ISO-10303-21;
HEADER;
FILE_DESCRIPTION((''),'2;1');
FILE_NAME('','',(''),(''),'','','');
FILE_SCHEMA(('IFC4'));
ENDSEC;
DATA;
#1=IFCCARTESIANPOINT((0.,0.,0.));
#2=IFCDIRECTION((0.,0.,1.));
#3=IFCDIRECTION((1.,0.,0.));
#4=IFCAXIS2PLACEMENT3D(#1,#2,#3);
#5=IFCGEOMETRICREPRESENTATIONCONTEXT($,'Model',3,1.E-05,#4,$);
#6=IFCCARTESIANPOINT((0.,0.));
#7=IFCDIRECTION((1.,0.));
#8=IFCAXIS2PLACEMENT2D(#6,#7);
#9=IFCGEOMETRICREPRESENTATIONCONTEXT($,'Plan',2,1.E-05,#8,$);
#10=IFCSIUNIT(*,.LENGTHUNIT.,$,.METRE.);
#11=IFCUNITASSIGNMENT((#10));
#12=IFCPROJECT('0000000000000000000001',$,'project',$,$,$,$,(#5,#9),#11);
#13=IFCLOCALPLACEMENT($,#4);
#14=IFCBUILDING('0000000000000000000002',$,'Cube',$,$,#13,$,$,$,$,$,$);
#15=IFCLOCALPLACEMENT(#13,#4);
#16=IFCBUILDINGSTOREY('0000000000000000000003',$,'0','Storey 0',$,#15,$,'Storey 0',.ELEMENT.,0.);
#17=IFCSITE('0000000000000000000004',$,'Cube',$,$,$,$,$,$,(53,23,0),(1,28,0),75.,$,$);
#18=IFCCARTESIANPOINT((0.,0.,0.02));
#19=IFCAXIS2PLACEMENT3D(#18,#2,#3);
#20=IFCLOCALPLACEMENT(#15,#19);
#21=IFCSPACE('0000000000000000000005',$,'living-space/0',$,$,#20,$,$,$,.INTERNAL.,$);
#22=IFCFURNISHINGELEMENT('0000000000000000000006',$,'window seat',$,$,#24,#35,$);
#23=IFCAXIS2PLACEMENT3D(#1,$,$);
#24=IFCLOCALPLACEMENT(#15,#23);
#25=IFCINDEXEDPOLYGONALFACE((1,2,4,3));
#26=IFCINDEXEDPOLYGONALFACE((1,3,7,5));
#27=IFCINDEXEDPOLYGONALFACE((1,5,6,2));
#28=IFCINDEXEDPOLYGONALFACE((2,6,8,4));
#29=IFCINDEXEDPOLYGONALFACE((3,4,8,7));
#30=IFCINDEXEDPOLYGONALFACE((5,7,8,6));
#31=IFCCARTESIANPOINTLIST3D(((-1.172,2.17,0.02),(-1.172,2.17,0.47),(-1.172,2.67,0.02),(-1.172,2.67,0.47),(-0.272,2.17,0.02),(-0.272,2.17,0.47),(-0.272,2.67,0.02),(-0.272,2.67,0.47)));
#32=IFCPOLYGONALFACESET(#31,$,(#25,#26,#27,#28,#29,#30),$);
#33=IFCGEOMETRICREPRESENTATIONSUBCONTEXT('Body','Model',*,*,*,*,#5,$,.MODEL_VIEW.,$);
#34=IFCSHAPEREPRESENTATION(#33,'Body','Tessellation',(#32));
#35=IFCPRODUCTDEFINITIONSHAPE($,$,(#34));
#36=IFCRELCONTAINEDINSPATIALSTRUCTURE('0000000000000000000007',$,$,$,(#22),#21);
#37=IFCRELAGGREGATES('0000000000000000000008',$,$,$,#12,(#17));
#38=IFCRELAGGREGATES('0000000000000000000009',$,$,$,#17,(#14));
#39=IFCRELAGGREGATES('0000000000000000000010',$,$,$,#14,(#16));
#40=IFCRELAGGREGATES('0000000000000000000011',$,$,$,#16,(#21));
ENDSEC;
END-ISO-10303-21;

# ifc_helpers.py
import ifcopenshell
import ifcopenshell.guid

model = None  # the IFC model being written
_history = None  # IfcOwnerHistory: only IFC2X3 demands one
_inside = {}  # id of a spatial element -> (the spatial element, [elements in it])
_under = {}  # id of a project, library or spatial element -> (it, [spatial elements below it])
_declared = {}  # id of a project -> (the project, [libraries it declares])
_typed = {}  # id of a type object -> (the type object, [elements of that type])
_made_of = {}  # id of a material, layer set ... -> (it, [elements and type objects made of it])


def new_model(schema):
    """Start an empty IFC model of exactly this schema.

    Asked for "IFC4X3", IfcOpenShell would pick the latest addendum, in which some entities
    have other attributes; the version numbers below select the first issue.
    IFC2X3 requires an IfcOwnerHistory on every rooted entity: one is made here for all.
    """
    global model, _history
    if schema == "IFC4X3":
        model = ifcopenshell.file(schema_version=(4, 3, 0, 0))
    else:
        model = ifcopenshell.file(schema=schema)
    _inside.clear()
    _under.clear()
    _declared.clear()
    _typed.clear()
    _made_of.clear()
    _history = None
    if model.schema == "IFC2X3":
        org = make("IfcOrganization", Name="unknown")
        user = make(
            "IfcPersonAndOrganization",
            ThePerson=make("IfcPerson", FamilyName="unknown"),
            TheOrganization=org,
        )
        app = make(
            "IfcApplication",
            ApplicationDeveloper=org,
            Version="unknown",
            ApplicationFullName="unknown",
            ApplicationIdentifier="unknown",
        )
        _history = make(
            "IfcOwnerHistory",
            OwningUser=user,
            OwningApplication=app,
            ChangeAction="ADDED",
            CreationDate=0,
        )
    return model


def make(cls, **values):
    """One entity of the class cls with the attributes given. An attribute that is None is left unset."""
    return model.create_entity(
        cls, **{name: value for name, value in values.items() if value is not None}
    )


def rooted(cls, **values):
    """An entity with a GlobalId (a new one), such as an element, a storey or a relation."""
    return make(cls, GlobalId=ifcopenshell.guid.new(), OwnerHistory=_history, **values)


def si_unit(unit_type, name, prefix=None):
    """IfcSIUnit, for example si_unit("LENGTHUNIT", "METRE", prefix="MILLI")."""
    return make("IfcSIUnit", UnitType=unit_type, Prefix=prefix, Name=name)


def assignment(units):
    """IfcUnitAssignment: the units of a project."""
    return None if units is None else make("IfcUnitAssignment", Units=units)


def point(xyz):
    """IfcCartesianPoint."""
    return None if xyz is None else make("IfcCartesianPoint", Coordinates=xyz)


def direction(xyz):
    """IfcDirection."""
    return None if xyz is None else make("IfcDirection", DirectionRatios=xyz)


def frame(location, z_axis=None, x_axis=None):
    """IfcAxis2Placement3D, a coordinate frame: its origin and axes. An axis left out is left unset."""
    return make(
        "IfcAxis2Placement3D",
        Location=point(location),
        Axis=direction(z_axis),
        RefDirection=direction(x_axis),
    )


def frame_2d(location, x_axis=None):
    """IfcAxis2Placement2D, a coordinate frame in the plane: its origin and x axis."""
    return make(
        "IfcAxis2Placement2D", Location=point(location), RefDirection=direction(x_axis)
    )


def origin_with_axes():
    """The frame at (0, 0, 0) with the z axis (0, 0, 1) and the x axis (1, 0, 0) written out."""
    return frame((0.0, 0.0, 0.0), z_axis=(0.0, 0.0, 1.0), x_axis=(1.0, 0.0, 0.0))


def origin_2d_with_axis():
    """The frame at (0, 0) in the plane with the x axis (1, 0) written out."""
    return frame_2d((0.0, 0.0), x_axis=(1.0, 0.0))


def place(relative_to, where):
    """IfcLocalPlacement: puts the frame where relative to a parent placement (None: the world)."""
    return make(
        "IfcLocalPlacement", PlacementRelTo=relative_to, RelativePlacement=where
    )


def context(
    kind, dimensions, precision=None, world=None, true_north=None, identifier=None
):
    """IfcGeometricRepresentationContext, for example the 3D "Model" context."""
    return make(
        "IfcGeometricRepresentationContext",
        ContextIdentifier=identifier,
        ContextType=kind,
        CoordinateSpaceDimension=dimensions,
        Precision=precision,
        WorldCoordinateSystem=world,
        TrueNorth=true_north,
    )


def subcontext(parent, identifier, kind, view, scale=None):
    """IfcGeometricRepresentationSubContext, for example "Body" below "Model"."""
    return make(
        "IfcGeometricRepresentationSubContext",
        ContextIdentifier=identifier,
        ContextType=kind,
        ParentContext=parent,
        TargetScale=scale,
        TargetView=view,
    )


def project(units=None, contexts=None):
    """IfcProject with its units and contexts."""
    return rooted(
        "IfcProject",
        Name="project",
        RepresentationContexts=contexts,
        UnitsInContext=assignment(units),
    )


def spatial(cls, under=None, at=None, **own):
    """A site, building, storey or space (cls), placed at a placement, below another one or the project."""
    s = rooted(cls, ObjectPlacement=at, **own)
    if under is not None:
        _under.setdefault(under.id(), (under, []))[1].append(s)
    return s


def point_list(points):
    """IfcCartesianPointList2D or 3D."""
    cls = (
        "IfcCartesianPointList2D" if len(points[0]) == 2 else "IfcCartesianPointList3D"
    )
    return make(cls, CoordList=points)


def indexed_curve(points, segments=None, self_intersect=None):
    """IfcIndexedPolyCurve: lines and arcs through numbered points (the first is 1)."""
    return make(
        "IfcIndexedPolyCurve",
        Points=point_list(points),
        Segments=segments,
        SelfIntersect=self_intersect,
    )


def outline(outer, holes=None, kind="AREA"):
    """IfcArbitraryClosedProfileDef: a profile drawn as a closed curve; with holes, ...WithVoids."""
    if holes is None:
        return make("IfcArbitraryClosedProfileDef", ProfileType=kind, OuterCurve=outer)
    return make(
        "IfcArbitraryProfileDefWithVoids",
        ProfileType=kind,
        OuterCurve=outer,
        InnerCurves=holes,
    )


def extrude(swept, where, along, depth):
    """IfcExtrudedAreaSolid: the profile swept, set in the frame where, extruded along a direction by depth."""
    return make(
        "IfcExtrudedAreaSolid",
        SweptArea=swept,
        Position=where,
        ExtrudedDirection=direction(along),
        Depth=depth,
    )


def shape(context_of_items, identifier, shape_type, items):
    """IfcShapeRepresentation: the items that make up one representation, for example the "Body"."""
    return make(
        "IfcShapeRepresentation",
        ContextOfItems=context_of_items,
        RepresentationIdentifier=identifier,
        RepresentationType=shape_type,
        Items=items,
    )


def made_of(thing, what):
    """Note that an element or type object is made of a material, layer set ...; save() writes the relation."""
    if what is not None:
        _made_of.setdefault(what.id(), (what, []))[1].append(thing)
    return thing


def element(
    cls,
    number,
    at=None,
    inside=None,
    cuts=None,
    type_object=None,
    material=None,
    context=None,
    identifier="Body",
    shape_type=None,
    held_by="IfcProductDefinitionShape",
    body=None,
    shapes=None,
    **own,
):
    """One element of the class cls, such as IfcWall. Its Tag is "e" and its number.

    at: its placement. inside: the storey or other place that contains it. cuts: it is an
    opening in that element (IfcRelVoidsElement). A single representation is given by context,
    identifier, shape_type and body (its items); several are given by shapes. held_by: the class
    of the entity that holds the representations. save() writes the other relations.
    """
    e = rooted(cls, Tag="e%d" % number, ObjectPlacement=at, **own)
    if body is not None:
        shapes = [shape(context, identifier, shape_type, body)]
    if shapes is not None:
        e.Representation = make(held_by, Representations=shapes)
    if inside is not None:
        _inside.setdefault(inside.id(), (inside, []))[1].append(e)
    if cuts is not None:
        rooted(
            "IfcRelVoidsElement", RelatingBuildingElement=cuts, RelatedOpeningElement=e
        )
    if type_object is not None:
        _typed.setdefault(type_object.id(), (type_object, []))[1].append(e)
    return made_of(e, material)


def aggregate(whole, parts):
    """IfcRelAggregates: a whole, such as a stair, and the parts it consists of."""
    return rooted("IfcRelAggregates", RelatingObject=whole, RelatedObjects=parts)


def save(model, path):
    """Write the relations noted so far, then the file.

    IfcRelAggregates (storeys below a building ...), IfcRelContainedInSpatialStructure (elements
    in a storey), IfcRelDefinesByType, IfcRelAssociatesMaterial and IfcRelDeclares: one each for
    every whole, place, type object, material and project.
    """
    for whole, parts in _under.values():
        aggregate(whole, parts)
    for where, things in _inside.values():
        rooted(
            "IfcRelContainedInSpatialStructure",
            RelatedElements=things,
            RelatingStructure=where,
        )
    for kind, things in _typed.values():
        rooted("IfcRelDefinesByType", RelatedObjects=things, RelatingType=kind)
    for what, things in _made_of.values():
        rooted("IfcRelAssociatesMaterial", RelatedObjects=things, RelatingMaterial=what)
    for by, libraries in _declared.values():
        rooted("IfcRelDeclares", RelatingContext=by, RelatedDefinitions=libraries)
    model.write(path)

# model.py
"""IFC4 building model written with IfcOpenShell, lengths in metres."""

from ifc_helpers import new_model, si_unit, frame, origin_with_axes, origin_2d_with_axis, place, context, subcontext, project, spatial, indexed_curve, outline, extrude, element, save


model = new_model("IFC4")

# Units and contexts
model_context = context("Model", 3, precision=1e-05, world=origin_with_axes())
plan_context = context("Plan", 2, precision=1e-05, world=origin_2d_with_axis())
body_context = subcontext(model_context, "Body", "Model", "MODEL_VIEW")
ifc_project = project(units=[si_unit("LENGTHUNIT", "METRE")], contexts=[model_context, plan_context])

# Site, building, storey
site = spatial("IfcSite", under=ifc_project, Name="Cube", RefLatitude=(53, 23, 0), RefLongitude=(1, 28, 0), RefElevation=75.0)
building_placement = place(None, origin_with_axes())
building = spatial("IfcBuilding", under=site, at=building_placement, Name="Cube")
storey_placement = place(building_placement, origin_with_axes())
storey = spatial("IfcBuildingStorey", under=building, at=storey_placement, Name="0", Description="Storey 0", LongName="Storey 0", CompositionType="ELEMENT", Elevation=0.0)

# Shared definitions
space_placement = place(storey_placement, frame((0.0, 0.0, 0.02), z_axis=(0.0, 0.0, 1.0), x_axis=(1.0, 0.0, 0.0)))
space = spatial("IfcSpace", under=storey, at=space_placement, Name="living-space/0", PredefinedType="INTERNAL")

# Furnishing element
furnishing_1_placement = place(space_placement, frame((-1.172, 2.17, 0.0), z_axis=(0.0, 0.0, 1.0), x_axis=(1.0, 0.0, 0.0)))
element("IfcFurnishingElement", 1, at=furnishing_1_placement, inside=space, Name="window seat", context=body_context, shape_type="SweptSolid", body=[
    extrude(outline(indexed_curve([(0.0, 0.0), (0.9, 0.0), (0.9, 0.5), (0.0, 0.5)])), None, (0.0, 0.0, 1.0), 0.45),
])

save(model, "model.ifc")
